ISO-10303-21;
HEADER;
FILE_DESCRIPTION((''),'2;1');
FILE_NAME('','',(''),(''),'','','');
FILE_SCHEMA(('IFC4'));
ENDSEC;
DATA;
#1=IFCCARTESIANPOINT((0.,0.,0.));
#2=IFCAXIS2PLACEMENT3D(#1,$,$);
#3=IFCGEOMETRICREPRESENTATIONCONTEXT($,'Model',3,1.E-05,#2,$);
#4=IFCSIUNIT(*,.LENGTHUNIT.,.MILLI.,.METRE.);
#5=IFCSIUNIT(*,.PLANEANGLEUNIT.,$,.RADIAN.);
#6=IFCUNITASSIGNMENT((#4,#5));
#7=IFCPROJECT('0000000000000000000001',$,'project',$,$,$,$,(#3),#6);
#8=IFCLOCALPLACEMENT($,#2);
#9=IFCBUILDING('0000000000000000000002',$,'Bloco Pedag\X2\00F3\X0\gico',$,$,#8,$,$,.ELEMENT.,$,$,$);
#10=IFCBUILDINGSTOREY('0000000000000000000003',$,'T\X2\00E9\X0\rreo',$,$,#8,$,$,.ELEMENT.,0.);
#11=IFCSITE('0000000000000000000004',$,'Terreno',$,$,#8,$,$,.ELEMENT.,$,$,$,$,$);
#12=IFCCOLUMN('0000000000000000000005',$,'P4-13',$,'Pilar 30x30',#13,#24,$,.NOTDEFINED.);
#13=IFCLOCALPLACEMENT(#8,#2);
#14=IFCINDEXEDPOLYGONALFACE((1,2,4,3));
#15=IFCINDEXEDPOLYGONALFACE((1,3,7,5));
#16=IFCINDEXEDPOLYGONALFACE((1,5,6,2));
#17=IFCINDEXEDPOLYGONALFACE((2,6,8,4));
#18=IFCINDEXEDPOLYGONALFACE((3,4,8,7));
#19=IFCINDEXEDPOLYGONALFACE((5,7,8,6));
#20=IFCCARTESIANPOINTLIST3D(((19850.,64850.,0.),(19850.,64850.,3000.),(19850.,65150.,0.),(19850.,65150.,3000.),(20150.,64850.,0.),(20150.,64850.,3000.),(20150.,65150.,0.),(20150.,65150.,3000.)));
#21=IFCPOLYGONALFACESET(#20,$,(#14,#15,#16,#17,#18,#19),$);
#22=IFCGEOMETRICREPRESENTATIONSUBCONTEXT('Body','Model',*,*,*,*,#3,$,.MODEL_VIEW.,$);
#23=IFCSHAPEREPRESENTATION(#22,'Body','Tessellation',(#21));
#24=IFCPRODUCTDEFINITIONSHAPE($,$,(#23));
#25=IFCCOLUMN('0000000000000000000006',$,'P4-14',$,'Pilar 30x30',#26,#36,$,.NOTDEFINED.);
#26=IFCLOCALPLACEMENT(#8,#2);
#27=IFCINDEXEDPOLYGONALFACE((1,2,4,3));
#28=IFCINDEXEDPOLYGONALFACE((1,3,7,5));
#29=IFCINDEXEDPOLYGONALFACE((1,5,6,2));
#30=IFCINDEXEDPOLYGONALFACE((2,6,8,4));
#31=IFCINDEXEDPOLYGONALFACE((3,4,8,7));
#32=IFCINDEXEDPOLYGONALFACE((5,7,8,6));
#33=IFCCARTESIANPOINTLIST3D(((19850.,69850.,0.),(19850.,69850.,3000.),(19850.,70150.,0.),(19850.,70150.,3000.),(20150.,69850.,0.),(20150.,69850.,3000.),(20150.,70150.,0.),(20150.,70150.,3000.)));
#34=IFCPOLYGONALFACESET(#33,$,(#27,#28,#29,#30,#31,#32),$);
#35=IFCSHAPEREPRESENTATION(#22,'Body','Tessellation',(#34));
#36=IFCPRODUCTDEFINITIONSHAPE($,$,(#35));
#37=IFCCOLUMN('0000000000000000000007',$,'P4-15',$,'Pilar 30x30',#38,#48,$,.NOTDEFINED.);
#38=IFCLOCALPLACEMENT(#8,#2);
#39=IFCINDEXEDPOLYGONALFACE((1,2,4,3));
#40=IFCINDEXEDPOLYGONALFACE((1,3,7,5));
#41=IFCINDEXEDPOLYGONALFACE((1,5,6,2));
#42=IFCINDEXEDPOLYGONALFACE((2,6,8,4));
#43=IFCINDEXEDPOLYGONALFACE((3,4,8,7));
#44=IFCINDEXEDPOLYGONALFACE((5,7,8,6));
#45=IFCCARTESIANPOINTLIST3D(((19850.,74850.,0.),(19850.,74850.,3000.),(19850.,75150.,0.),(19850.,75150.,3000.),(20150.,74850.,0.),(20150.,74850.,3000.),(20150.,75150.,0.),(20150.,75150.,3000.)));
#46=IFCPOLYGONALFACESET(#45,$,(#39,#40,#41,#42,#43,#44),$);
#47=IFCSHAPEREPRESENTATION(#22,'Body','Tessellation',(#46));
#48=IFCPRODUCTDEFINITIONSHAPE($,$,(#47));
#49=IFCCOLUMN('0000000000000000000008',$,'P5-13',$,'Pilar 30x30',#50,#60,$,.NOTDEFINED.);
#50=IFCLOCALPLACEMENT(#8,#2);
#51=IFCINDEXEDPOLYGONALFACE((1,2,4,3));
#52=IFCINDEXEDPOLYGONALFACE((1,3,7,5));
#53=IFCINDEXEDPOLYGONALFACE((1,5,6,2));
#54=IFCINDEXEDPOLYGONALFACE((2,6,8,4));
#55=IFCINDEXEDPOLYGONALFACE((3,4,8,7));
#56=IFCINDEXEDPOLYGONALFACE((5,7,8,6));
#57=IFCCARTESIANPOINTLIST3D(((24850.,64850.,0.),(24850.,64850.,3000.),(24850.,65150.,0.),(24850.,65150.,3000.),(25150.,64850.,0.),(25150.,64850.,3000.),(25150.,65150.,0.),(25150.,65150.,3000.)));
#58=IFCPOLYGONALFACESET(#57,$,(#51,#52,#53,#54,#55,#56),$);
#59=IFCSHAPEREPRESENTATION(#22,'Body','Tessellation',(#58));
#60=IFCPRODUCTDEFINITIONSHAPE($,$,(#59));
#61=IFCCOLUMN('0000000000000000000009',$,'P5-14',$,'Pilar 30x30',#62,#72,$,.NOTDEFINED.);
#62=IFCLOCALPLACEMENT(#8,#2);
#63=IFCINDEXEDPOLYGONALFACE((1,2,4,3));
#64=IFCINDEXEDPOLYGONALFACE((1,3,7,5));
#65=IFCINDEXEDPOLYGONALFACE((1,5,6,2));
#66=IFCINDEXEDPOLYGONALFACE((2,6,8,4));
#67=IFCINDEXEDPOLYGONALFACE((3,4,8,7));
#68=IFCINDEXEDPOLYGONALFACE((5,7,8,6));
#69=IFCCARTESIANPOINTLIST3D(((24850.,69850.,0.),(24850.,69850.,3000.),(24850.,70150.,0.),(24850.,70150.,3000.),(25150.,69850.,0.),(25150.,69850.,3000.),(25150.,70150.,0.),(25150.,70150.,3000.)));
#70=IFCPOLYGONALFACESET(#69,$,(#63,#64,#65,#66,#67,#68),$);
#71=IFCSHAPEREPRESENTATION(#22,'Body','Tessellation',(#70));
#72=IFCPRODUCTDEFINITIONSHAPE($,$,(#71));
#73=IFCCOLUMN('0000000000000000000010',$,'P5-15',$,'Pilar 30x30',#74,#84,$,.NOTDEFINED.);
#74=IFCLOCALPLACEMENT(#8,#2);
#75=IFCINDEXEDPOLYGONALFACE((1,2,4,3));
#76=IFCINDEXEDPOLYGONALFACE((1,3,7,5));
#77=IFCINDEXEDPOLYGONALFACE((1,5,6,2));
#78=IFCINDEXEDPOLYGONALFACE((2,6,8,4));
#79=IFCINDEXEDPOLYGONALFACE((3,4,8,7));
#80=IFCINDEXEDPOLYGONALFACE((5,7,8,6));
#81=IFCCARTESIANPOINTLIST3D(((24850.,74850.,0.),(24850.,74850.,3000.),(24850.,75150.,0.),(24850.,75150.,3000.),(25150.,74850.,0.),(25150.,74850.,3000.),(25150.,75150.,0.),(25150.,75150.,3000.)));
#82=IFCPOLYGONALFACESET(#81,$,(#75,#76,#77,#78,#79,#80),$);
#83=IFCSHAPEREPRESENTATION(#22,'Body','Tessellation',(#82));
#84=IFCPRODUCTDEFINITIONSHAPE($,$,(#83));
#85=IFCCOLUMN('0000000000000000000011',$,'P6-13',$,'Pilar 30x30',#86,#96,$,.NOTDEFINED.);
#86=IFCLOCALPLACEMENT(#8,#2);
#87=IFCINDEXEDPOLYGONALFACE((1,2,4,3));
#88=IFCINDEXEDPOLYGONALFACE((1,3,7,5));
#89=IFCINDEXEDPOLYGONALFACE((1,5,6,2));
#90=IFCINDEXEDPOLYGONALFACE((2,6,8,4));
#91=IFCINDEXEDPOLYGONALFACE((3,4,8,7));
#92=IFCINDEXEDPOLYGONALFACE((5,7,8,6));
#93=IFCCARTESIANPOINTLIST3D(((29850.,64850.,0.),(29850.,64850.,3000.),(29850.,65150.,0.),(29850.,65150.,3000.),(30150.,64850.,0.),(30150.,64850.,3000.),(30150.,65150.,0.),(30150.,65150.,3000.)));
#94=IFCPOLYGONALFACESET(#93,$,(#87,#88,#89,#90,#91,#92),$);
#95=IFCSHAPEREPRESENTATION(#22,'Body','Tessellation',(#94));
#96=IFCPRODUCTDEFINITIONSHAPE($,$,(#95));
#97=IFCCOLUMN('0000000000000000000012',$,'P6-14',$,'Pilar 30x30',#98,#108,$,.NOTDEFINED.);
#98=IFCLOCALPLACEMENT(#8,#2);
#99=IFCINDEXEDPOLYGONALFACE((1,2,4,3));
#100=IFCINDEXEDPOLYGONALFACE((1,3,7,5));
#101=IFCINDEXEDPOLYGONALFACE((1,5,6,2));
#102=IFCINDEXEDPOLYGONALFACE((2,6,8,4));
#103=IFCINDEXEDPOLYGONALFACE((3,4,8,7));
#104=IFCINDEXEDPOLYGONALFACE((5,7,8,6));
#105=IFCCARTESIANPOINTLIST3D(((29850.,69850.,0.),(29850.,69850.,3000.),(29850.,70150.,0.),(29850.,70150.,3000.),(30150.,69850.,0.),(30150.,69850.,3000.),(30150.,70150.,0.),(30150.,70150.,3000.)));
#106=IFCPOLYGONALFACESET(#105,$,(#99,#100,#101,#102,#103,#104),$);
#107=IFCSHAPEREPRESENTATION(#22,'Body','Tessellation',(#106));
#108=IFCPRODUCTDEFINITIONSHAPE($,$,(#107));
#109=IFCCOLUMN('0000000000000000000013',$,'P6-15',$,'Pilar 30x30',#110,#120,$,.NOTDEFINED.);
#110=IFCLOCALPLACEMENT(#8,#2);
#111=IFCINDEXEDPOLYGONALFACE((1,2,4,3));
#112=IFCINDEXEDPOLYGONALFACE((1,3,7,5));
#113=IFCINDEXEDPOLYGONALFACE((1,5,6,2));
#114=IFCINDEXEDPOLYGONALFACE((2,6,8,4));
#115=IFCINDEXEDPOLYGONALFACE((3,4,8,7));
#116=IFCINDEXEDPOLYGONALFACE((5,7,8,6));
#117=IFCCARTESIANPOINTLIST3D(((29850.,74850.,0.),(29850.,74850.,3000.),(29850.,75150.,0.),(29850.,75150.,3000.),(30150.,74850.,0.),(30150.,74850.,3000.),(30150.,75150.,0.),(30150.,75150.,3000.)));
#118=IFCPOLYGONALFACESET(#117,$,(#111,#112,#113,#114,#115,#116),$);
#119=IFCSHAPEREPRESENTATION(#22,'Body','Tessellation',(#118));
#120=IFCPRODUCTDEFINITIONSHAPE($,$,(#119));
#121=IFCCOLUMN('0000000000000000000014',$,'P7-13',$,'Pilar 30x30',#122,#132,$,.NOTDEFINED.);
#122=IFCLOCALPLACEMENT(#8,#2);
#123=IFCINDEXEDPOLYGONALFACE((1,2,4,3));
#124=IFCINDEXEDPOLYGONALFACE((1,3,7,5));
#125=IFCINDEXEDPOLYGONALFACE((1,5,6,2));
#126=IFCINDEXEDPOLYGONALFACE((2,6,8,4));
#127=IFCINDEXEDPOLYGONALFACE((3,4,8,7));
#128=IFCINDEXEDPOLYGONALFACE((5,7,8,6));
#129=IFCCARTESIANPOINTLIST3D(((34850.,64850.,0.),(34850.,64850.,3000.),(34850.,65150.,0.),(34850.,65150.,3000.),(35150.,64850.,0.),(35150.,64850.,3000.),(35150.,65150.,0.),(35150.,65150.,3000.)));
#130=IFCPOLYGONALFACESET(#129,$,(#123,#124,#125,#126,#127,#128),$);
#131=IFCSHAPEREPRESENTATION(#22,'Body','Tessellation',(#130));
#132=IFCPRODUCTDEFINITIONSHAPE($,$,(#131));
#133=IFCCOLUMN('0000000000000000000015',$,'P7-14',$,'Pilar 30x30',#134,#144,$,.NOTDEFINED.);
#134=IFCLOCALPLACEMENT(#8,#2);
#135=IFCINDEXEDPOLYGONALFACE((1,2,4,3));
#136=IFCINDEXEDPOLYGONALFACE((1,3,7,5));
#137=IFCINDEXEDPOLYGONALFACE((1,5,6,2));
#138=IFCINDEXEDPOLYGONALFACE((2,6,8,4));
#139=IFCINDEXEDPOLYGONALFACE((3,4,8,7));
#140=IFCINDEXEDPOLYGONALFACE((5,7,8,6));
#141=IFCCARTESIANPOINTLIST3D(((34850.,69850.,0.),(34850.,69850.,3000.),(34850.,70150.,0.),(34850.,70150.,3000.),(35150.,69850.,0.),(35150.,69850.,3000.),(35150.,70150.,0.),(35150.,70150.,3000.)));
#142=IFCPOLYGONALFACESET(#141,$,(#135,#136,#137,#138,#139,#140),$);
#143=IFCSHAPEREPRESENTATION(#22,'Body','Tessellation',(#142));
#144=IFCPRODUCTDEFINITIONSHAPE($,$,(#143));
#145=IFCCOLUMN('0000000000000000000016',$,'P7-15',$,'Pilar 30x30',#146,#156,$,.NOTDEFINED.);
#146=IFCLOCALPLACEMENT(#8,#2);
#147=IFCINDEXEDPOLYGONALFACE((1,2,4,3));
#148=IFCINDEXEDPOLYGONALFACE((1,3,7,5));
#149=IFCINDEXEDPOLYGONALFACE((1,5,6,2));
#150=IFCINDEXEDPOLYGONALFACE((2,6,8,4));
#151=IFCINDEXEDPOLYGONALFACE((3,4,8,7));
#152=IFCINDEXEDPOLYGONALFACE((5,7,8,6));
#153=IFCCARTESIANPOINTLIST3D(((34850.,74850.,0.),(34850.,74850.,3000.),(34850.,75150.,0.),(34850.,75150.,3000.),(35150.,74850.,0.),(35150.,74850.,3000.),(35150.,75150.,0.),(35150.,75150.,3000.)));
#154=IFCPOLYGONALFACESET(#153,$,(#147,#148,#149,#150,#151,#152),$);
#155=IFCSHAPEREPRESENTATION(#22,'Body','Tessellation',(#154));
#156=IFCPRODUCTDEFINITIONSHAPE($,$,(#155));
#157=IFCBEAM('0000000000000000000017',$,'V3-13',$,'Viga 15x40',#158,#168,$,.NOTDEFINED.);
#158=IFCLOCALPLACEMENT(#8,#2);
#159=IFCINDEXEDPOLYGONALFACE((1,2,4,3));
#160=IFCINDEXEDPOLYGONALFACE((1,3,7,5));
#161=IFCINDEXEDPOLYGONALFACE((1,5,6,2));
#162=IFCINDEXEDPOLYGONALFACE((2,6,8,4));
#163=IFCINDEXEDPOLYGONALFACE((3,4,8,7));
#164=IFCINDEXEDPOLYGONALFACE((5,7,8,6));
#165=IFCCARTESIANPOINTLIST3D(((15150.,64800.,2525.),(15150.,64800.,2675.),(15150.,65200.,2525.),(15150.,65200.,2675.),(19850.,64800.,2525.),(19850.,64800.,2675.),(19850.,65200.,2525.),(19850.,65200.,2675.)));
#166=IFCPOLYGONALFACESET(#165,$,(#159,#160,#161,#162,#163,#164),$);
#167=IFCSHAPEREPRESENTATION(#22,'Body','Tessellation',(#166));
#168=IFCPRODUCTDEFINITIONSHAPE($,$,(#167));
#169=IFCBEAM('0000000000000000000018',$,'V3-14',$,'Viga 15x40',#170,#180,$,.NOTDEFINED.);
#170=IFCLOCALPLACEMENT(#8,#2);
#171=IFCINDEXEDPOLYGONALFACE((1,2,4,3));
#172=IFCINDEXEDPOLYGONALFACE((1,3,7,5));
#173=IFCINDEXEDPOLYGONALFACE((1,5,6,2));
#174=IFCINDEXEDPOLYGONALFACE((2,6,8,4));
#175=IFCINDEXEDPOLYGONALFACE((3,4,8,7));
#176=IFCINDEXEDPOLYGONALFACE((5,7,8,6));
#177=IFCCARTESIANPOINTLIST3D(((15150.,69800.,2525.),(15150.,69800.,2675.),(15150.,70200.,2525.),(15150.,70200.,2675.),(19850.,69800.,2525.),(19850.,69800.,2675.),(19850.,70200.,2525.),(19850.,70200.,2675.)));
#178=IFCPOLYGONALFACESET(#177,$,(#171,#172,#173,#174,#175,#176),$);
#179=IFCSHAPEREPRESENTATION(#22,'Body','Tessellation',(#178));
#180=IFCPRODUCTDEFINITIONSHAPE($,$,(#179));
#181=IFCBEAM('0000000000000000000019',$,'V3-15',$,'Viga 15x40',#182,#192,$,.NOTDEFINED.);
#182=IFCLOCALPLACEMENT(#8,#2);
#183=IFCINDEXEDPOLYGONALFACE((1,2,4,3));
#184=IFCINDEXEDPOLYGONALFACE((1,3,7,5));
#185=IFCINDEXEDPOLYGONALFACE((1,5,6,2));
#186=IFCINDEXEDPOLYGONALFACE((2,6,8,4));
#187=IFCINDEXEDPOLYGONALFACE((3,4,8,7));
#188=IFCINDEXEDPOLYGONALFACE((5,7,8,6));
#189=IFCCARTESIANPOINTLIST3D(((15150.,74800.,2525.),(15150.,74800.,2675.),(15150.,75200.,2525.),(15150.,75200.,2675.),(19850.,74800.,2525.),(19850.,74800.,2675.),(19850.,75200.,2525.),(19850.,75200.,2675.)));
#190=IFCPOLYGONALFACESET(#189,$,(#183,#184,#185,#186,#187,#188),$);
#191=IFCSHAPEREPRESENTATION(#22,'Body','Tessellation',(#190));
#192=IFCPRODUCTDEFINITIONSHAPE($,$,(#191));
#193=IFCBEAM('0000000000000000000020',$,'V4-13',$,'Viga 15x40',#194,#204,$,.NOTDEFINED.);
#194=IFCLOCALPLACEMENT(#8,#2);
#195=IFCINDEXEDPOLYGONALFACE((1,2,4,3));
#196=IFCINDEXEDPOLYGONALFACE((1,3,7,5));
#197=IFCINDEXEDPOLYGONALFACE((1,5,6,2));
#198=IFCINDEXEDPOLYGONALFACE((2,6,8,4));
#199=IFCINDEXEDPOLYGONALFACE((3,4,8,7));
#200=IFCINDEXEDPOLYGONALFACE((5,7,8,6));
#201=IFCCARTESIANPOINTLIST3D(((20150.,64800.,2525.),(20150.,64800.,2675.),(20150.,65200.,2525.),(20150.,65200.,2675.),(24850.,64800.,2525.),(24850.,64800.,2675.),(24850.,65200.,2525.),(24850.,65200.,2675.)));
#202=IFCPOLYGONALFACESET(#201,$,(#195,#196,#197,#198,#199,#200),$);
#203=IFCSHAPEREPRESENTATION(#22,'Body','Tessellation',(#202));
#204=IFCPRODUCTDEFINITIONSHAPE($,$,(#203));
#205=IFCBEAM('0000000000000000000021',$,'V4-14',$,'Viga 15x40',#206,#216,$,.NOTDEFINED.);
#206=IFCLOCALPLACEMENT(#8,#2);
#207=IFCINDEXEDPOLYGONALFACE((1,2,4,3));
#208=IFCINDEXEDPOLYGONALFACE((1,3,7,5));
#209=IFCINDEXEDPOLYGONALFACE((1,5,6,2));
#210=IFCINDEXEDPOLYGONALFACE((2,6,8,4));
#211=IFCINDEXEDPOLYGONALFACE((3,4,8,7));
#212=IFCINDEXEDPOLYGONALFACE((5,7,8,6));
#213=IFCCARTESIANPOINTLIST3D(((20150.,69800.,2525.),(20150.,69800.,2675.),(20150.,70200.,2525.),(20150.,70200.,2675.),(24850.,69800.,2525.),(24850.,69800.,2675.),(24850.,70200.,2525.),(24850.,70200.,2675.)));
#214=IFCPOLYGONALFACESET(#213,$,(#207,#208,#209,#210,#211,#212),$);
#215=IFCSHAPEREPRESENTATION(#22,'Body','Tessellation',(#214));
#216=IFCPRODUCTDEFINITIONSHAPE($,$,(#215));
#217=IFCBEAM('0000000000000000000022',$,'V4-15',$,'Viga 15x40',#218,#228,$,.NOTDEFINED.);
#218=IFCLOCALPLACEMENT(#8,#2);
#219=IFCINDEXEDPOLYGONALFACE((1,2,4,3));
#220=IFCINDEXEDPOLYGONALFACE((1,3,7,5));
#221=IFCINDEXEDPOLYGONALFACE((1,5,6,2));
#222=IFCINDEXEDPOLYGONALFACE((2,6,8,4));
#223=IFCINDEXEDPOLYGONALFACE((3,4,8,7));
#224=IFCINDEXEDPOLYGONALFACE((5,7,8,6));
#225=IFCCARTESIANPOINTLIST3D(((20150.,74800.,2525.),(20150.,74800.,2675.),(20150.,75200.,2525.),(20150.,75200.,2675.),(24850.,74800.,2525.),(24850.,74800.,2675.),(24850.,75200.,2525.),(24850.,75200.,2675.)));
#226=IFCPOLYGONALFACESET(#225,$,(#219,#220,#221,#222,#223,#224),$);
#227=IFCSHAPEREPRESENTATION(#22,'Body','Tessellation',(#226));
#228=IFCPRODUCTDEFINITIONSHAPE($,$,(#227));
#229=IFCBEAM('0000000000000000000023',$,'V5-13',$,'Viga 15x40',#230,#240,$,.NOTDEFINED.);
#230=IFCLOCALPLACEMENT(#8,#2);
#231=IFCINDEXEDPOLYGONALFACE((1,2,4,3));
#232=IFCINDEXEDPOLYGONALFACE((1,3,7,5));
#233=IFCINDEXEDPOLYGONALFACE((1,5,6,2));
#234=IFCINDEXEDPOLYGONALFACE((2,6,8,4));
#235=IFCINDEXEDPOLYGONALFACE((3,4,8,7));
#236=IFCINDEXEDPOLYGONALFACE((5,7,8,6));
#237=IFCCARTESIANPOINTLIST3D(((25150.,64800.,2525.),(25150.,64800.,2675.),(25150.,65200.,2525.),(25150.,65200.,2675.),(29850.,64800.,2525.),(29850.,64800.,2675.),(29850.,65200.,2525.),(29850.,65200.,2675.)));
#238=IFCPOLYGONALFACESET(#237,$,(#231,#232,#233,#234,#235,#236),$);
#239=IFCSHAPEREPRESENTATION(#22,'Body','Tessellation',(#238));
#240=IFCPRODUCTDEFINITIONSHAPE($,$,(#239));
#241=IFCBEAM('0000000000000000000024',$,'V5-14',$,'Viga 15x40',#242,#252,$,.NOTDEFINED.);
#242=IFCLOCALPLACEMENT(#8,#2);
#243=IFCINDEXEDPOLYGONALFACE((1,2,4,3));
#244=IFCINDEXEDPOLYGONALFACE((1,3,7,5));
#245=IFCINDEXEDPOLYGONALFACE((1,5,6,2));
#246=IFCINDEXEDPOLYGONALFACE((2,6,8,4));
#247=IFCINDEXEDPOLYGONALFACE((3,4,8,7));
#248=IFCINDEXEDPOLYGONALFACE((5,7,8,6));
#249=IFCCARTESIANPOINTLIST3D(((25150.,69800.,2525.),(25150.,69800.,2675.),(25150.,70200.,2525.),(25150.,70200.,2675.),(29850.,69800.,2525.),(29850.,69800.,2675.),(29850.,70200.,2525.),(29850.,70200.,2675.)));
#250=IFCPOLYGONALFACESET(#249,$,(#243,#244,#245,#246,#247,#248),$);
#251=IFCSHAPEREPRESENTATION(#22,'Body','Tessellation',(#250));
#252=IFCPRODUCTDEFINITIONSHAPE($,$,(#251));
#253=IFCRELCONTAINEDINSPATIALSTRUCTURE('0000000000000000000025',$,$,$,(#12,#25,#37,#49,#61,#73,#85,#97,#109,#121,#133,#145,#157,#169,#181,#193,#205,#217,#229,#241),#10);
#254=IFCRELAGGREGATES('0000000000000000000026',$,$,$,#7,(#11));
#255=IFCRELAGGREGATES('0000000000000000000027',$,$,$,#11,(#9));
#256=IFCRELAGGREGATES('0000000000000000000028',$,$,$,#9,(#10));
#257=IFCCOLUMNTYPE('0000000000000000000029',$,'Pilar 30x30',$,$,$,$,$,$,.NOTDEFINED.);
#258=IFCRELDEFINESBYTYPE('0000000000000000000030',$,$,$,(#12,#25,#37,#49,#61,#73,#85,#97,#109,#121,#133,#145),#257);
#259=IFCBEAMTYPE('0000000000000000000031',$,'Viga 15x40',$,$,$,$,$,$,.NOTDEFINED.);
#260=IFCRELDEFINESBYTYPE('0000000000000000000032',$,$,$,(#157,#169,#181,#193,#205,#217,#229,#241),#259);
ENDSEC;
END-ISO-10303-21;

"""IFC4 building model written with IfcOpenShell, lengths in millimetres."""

from ifc_helpers import new_model, si_unit, frame, origin, origin_2d, place, context, subcontext, project, spatial, rectangle, extrude, type_object, element, save


model = new_model("IFC4")

# Units and contexts
model_context = context("Model", 3, precision=1e-05, world=origin())
body_context = subcontext(model_context, "Body", "Model", "MODEL_VIEW")
ifc_project = project(units=[si_unit("LENGTHUNIT", "METRE", prefix="MILLI"), si_unit("PLANEANGLEUNIT", "RADIAN")], contexts=[model_context])

# Site, building, storey
placement = place(None, origin())
site = spatial("IfcSite", under=ifc_project, at=placement, Name="Terreno", CompositionType="ELEMENT")
building = spatial("IfcBuilding", under=site, at=placement, Name="Bloco Pedagógico", CompositionType="ELEMENT")
storey = spatial("IfcBuildingStorey", under=building, at=placement, Name="Térreo", CompositionType="ELEMENT", Elevation=0.0)

# Columns
column_type = type_object("IfcColumnType", Name="Pilar 30x30", PredefinedType="NOTDEFINED")
for number, where, z_axis, x_axis, name in (
    (1, (20000.0, 65000.0, 0.0), (0.0, 0.0, 1.0), (1.0, 0.0, 0.0), "P4-13"),
    (2, (20000.0, 70000.0, 0.0), (0.0, 0.0, 1.0), (1.0, 0.0, 0.0), "P4-14"),
    (3, (20000.0, 75000.0, 0.0), (0.0, 0.0, 1.0), (1.0, 0.0, 0.0), "P4-15"),
    (4, (25000.0, 65000.0, 0.0), (0.0, 0.0, 1.0), (1.0, 0.0, 0.0), "P5-13"),
    (5, (25000.0, 70000.0, 0.0), (0.0, 0.0, 1.0), (1.0, 0.0, 0.0), "P5-14"),
    (6, (25000.0, 75000.0, 0.0), (0.0, 0.0, 1.0), (1.0, 0.0, 0.0), "P5-15"),
    (7, (30000.0, 65000.0, 0.0), (0.0, 0.0, 1.0), (1.0, 0.0, 0.0), "P6-13"),
    (8, (30000.0, 70000.0, 0.0), (0.0, 0.0, 1.0), (1.0, 0.0, 0.0), "P6-14"),
    (9, (30000.0, 75000.0, 0.0), (0.0, 0.0, 1.0), (1.0, 0.0, 0.0), "P6-15"),
    (10, (35000.0, 65000.0, 0.0), (0.0, 0.0, 1.0), (1.0, 0.0, 0.0), "P7-13"),
    (11, (35000.0, 70000.0, 0.0), (0.0, 0.0, 1.0), (1.0, 0.0, 0.0), "P7-14"),
    (12, (35000.0, 75000.0, 0.0), (0.0, 0.0, 1.0), (1.0, 0.0, 0.0), "P7-15"),
):
    element("IfcColumn", number, at=place(None, frame(where, z_axis=z_axis, x_axis=x_axis)), inside=storey, type_object=column_type, Name=name, ObjectType="Pilar 30x30", PredefinedType="NOTDEFINED", context=body_context, shape_type="SweptSolid", body=[
        extrude(rectangle(XDim=300.0, YDim=300.0, at=origin_2d()), None, (0.0, 0.0, 1.0), 3000.0),
    ])

# Beams
beam_type = type_object("IfcBeamType", Name="Viga 15x40", PredefinedType="NOTDEFINED")
for number, where, z_axis, x_axis, name in (
    (13, (15150.0, 65000.0, 2600.0), (1.0, 0.0, 0.0), (0.0, 1.0, 0.0), "V3-13"),
    (14, (15150.0, 70000.0, 2600.0), (1.0, 0.0, 0.0), (0.0, 1.0, 0.0), "V3-14"),
    (15, (15150.0, 75000.0, 2600.0), (1.0, 0.0, 0.0), (0.0, 1.0, 0.0), "V3-15"),
    (16, (20150.0, 65000.0, 2600.0), (1.0, 0.0, 0.0), (0.0, 1.0, 0.0), "V4-13"),
    (17, (20150.0, 70000.0, 2600.0), (1.0, 0.0, 0.0), (0.0, 1.0, 0.0), "V4-14"),
    (18, (20150.0, 75000.0, 2600.0), (1.0, 0.0, 0.0), (0.0, 1.0, 0.0), "V4-15"),
    (19, (25150.0, 65000.0, 2600.0), (1.0, 0.0, 0.0), (0.0, 1.0, 0.0), "V5-13"),
    (20, (25150.0, 70000.0, 2600.0), (1.0, 0.0, 0.0), (0.0, 1.0, 0.0), "V5-14"),
):
    element("IfcBeam", number, at=place(None, frame(where, z_axis=z_axis, x_axis=x_axis)), inside=storey, type_object=beam_type, Name=name, ObjectType="Viga 15x40", PredefinedType="NOTDEFINED", context=body_context, shape_type="SweptSolid", body=[
        extrude(rectangle(XDim=400.0, YDim=150.0, at=origin_2d()), None, (0.0, 0.0, 1.0), 4700.0),
    ])

save(model, "model.ifc")
